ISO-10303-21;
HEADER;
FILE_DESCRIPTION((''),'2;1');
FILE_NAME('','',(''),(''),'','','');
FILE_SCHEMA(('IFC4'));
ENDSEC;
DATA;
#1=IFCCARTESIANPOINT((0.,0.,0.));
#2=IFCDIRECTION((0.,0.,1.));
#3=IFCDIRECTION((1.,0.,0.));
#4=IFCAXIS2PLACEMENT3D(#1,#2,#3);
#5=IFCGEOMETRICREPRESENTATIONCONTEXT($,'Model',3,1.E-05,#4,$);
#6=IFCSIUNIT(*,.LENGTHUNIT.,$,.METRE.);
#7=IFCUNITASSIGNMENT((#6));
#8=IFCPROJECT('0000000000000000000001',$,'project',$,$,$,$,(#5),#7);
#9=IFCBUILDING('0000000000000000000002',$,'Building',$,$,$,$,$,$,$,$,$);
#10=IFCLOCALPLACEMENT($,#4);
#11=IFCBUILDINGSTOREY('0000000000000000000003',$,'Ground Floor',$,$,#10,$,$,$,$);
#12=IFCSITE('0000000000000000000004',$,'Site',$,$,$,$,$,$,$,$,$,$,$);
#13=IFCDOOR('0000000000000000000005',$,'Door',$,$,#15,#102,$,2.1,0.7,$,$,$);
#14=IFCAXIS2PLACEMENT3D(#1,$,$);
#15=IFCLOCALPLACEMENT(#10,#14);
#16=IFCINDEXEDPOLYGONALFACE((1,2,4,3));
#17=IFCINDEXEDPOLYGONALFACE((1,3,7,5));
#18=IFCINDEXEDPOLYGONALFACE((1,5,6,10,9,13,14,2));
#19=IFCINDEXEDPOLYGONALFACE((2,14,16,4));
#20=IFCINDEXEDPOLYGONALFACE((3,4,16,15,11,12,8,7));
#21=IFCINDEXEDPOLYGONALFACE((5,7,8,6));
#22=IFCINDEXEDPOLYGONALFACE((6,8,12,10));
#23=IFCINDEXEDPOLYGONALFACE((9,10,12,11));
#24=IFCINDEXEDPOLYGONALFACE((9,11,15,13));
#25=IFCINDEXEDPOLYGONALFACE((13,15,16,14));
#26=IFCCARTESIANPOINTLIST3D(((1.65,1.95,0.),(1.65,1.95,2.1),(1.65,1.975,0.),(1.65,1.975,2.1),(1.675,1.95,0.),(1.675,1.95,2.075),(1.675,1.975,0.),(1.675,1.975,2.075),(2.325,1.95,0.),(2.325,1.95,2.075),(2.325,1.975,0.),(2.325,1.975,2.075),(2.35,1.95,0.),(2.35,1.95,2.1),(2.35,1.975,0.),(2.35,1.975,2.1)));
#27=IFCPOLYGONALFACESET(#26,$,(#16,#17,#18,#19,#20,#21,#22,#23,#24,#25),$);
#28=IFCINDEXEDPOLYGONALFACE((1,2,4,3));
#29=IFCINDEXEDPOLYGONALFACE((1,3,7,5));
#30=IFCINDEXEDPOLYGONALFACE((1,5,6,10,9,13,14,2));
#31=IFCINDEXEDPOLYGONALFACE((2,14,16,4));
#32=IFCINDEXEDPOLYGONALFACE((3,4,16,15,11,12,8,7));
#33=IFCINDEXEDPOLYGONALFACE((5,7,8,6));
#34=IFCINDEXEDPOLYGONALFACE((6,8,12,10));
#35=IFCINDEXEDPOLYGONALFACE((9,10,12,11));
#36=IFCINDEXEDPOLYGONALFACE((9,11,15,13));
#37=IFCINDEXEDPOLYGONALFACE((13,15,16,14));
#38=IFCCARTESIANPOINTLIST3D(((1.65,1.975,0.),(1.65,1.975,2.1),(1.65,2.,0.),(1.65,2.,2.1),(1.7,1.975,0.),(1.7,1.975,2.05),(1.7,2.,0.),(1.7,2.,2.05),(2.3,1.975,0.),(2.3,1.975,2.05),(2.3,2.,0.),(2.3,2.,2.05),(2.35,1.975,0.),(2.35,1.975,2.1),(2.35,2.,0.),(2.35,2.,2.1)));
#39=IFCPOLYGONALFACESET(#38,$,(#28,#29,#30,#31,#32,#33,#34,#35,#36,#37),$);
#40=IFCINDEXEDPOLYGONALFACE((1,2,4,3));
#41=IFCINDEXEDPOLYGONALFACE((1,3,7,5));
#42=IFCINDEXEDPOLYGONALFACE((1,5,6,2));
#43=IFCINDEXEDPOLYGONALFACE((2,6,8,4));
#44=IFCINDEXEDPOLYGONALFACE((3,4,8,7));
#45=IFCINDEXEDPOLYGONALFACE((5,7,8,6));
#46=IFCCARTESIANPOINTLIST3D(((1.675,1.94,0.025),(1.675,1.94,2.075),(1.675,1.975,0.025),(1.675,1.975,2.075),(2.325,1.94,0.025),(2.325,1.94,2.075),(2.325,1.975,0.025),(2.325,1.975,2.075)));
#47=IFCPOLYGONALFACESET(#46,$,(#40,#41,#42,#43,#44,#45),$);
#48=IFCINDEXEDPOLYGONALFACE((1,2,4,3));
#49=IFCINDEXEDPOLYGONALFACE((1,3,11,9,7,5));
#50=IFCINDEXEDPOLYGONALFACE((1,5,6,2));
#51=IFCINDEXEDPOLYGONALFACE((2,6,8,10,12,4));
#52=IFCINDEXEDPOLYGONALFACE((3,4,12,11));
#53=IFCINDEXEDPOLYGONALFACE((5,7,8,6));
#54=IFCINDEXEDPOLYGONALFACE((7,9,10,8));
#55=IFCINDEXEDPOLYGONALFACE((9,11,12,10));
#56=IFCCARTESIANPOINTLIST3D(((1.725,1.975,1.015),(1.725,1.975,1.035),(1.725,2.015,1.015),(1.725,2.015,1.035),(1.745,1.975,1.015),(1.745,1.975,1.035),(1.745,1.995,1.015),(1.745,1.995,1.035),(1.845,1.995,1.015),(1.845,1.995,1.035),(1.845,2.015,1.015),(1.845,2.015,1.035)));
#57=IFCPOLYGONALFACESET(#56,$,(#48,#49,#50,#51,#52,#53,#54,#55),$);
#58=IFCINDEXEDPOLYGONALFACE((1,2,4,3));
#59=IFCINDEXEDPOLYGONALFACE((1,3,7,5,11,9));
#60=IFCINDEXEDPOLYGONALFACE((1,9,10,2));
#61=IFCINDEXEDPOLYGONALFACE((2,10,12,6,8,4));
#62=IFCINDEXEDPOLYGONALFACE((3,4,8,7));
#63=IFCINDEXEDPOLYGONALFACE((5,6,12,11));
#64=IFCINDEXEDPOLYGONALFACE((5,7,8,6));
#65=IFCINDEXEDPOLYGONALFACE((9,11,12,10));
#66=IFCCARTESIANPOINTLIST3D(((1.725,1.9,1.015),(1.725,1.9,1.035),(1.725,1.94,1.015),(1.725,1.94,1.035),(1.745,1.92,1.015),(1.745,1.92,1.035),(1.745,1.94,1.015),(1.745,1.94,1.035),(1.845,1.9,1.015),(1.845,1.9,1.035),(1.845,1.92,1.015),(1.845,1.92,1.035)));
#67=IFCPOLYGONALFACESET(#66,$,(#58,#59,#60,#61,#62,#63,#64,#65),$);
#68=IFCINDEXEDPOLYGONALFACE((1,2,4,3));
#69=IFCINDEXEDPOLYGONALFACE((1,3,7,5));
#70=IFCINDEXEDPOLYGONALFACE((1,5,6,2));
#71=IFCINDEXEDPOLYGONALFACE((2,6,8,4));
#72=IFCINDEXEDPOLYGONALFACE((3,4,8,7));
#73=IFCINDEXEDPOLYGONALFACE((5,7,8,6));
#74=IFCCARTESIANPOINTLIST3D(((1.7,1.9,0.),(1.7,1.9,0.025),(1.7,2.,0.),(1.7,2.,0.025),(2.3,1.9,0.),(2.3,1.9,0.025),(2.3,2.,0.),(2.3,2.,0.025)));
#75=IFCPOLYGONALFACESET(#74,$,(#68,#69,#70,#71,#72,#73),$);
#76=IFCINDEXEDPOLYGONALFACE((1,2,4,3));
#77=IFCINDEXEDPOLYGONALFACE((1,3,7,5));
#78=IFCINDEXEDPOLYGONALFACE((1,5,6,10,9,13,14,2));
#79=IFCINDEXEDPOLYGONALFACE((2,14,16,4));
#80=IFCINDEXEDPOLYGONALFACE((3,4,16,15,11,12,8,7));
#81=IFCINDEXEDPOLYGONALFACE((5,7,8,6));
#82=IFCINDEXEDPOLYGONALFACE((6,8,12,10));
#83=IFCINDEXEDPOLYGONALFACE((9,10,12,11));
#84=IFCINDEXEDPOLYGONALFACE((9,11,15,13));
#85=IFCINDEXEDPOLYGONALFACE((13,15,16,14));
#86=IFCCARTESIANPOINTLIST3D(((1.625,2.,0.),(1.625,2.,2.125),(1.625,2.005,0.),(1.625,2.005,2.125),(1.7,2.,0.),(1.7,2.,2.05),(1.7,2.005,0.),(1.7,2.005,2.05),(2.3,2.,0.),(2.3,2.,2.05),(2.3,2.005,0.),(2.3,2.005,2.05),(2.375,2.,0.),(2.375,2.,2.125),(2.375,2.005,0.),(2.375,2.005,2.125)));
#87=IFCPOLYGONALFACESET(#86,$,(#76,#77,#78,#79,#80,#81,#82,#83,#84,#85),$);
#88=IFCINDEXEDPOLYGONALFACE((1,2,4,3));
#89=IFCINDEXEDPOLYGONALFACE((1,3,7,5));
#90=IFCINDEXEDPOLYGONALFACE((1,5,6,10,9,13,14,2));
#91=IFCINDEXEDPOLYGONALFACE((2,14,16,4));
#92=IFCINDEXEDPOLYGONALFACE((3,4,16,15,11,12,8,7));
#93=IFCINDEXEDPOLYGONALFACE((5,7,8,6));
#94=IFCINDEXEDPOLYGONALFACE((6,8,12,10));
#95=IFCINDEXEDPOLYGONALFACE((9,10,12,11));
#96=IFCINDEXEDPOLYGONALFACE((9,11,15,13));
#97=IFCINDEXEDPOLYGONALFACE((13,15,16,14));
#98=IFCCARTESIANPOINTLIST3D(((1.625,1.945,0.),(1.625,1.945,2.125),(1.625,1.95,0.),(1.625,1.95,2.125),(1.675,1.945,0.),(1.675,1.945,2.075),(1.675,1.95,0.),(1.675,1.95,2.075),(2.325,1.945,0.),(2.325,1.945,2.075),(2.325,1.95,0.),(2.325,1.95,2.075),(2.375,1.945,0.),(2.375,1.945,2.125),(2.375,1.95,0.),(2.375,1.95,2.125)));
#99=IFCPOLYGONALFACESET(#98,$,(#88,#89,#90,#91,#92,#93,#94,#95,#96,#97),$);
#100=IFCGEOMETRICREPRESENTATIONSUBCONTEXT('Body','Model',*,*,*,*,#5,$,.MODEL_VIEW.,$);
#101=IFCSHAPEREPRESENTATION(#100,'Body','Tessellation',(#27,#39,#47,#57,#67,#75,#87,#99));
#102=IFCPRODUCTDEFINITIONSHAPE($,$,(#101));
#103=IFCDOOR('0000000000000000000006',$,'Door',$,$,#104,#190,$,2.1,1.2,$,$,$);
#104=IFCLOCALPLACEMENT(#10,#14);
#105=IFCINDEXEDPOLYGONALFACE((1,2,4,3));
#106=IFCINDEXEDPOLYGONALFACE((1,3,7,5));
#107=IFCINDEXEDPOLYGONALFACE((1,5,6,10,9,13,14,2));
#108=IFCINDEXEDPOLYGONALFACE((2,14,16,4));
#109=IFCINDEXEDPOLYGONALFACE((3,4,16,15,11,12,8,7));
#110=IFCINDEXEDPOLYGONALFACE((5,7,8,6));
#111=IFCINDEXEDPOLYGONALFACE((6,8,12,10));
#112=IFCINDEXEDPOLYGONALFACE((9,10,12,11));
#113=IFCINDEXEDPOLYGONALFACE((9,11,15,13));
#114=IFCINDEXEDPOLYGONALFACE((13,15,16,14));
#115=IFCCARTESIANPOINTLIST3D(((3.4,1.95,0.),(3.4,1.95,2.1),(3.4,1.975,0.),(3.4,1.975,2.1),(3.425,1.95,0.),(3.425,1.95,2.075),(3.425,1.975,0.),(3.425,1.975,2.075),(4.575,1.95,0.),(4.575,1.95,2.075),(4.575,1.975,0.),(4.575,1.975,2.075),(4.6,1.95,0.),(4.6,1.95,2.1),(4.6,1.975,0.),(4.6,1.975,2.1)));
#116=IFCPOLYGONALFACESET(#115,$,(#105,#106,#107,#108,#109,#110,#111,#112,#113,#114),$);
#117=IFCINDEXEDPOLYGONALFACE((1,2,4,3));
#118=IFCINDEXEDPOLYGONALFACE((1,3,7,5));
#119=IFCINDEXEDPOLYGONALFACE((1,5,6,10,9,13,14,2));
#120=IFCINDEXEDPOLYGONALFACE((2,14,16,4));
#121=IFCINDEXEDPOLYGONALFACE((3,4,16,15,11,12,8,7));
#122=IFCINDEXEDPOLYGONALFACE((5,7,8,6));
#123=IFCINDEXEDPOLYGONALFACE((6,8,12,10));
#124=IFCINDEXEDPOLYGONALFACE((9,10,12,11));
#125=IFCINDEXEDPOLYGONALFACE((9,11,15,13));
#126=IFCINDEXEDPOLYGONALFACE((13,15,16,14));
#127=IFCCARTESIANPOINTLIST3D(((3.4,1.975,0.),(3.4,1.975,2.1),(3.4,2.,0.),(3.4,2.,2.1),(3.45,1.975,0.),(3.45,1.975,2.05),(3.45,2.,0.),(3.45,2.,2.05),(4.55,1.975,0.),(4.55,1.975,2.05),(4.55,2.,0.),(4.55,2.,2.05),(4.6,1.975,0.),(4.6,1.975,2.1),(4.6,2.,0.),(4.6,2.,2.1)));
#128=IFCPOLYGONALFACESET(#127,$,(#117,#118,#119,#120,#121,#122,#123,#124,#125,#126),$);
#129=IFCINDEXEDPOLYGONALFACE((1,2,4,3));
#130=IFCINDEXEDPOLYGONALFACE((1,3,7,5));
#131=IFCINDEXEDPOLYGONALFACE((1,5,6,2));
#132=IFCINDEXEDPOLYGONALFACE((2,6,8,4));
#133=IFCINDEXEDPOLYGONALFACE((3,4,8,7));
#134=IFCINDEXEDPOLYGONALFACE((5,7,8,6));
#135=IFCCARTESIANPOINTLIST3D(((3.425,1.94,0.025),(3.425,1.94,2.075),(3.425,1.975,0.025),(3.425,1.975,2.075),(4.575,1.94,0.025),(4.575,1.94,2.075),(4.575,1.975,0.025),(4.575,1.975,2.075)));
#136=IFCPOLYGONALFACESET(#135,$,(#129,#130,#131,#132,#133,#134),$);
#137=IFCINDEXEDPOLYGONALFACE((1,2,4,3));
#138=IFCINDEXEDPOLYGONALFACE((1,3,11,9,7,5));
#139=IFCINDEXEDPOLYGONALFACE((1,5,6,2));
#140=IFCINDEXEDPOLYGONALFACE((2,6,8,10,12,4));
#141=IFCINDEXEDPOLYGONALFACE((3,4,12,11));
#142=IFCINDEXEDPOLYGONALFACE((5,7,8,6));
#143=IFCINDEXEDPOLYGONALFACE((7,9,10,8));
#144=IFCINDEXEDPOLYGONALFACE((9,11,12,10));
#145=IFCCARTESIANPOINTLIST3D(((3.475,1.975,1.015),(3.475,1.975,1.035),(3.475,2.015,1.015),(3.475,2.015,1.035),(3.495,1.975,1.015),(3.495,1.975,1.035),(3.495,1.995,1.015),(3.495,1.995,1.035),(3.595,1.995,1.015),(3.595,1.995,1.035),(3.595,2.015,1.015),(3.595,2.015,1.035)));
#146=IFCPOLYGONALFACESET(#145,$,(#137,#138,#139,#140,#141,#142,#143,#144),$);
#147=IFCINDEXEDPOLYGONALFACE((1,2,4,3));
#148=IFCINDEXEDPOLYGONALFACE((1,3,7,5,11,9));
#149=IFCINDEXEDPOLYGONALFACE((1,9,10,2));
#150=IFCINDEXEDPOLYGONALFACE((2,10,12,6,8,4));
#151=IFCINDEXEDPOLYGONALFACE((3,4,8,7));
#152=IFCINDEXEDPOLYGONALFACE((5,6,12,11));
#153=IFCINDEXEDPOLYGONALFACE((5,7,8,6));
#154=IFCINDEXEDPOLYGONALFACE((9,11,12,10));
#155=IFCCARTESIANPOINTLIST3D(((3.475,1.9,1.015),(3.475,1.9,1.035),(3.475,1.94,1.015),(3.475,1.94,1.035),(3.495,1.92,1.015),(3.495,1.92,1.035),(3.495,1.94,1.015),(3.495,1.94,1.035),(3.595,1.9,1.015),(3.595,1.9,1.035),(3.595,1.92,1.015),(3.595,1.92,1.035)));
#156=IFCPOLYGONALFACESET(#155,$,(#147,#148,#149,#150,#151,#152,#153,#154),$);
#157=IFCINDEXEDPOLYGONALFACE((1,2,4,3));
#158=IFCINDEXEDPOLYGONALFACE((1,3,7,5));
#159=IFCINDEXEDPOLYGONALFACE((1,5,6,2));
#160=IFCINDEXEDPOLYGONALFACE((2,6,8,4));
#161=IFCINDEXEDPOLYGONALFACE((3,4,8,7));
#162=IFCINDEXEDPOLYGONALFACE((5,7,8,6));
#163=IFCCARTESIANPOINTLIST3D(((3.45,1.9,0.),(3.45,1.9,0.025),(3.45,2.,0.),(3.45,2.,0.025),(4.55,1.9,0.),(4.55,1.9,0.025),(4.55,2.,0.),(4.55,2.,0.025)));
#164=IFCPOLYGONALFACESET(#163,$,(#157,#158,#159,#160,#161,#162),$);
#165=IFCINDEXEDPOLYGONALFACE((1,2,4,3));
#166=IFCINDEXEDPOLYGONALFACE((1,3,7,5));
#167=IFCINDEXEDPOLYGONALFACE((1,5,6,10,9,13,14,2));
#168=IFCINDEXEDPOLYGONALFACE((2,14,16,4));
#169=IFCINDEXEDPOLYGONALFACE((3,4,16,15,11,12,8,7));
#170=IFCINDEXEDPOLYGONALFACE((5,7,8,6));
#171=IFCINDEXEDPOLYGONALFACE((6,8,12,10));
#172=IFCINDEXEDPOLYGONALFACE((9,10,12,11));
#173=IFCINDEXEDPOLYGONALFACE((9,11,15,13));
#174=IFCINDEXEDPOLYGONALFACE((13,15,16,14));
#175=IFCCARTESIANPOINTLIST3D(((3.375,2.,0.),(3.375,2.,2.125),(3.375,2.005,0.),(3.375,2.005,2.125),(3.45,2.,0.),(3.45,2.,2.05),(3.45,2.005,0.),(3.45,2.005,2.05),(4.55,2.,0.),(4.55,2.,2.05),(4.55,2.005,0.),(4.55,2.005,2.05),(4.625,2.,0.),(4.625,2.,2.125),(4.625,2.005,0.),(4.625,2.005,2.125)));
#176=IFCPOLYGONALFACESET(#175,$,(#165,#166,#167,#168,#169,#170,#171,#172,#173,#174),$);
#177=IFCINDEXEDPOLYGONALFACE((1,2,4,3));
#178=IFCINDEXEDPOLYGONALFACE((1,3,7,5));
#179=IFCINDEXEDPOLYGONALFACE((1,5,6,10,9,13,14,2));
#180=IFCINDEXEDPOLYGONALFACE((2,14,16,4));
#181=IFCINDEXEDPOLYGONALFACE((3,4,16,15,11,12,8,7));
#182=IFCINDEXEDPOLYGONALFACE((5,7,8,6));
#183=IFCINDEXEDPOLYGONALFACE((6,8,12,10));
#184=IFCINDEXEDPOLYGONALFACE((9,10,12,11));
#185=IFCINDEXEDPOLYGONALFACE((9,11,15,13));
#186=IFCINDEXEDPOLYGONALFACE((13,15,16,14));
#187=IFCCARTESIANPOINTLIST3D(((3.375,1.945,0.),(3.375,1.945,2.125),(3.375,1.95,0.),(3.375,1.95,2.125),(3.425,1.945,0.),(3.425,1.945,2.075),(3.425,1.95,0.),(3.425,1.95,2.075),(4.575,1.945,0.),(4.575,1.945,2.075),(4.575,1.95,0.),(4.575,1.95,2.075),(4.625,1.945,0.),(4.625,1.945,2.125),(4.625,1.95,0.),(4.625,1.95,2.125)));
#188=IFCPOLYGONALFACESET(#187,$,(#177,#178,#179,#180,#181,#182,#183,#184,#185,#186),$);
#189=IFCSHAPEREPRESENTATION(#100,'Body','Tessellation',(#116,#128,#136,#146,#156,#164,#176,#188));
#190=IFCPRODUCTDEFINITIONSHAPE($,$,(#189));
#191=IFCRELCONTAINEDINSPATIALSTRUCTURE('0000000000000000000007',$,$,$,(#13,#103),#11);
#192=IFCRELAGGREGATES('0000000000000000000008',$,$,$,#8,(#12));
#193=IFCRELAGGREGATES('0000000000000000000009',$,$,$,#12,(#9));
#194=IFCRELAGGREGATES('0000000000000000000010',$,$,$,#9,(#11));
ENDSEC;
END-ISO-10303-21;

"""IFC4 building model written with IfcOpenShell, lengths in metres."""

from ifc_helpers import new_model, si_unit, frame, origin_with_axes, place, context, subcontext, project, spatial, line, indexed_curve, outline, extrude, element, save


model = new_model("IFC4")

# Units and contexts
model_context = context("Model", 3, precision=1e-05, world=origin_with_axes())
body_context = subcontext(model_context, "Body", "Model", "MODEL_VIEW")
ifc_project = project(units=[si_unit("LENGTHUNIT", "METRE")], contexts=[model_context])

# Site, building, storey
site = spatial("IfcSite", under=ifc_project, Name="Site")
building = spatial("IfcBuilding", under=site, Name="Building")
storey_placement = place(None, origin_with_axes())
storey = spatial("IfcBuildingStorey", under=building, at=storey_placement, Name="Ground Floor")

# Doors
door_1_placement = place(storey_placement, frame((2.35, 2.0, 0.0), z_axis=(0.0, 0.0, 1.0), x_axis=(-1.0, 0.0, 0.0)))
element("IfcDoor", 1, at=door_1_placement, inside=storey, Name="Door", OverallHeight=2.1, OverallWidth=0.7, context=body_context, shape_type="SweptSolid", body=[
    extrude(outline(indexed_curve([(0.0, 0.0), (0.0, 2.1), (0.7, 2.1), (0.7, 0.0), (0.675, 0.0), (0.675, 2.075), (0.025, 2.075), (0.025, 0.0)], segments=[line(1, 2, 3, 4, 5, 6, 7, 8, 1)])), frame((0.0, 0.025, 0.0), z_axis=(0.0, -1.0, 0.0), x_axis=(1.0, 0.0, 0.0)), (0.0, 0.0, -1.0), 0.025),
    extrude(outline(indexed_curve([(0.0, 0.0), (0.0, 2.1), (0.7, 2.1), (0.7, 0.0), (0.65, 0.0), (0.65, 2.05), (0.05, 2.05), (0.05, 0.0)], segments=[line(1, 2, 3, 4, 5, 6, 7, 8, 1)])), frame((0.0, 0.0, 0.0), z_axis=(0.0, -1.0, 0.0), x_axis=(1.0, 0.0, 0.0)), (0.0, 0.0, -1.0), 0.025),
    extrude(outline(indexed_curve([(0.0, 0.0), (0.65, 0.0), (0.65, 0.035), (0.0, 0.035)], segments=[line(1, 2, 3, 4, 1)])), frame((0.025, 0.025, 0.025), z_axis=(0.0, 0.0, 1.0), x_axis=(1.0, 0.0, 0.0)), (0.0, 0.0, 1.0), 2.05),
    extrude(outline(indexed_curve([(0.0, 0.0), (0.0, -0.04), (-0.12, -0.04), (-0.12, -0.02), (-0.02, -0.02), (-0.02, 0.0)], segments=[line(1, 2, 3, 4, 5, 6, 1)])), frame((0.625, 0.025, 1.015), z_axis=(0.0, 0.0, 1.0), x_axis=(1.0, 0.0, 0.0)), (0.0, 0.0, 1.0), 0.02),
    extrude(outline(indexed_curve([(0.0, 0.0), (0.0, 0.04), (-0.12, 0.04), (-0.12, 0.02), (-0.02, 0.02), (-0.02, 0.0)], segments=[line(1, 2, 3, 4, 5, 6, 1)])), frame((0.625, 0.06, 1.015), z_axis=(0.0, 0.0, 1.0), x_axis=(1.0, 0.0, 0.0)), (0.0, 0.0, 1.0), 0.02),
    extrude(outline(indexed_curve([(0.0, 0.0), (0.6, 0.0), (0.6, 0.1), (0.0, 0.1)], segments=[line(1, 2, 3, 4, 1)])), frame((0.05, 0.0, 0.0), z_axis=(0.0, 0.0, 1.0), x_axis=(1.0, 0.0, 0.0)), (0.0, 0.0, 1.0), 0.025),
    extrude(outline(indexed_curve([(0.0, 0.0), (0.0, 2.125), (0.75, 2.125), (0.75, 0.0), (0.675, 0.0), (0.675, 2.05), (0.075, 2.05), (0.075, 0.0)], segments=[line(1, 2, 3, 4, 5, 6, 7, 8, 1)])), frame((-0.025, -0.005, 0.0), z_axis=(0.0, -1.0, 0.0), x_axis=(1.0, 0.0, 0.0)), (0.0, 0.0, -1.0), 0.005),
    extrude(outline(indexed_curve([(0.0, 0.0), (0.0, 2.125), (0.75, 2.125), (0.75, 0.0), (0.7, 0.0), (0.7, 2.075), (0.05, 2.075), (0.05, 0.0)], segments=[line(1, 2, 3, 4, 5, 6, 7, 8, 1)])), frame((-0.025, 0.05, 0.0), z_axis=(0.0, -1.0, 0.0), x_axis=(1.0, 0.0, 0.0)), (0.0, 0.0, -1.0), 0.005),
])
door_2_placement = place(storey_placement, frame((4.6, 2.0, 0.0), z_axis=(0.0, 0.0, 1.0), x_axis=(-1.0, 0.0, 0.0)))
element("IfcDoor", 2, at=door_2_placement, inside=storey, Name="Door", OverallHeight=2.1, OverallWidth=1.2, context=body_context, shape_type="SweptSolid", body=[
    extrude(outline(indexed_curve([(0.0, 0.0), (0.0, 2.1), (1.2, 2.1), (1.2, 0.0), (1.175, 0.0), (1.175, 2.075), (0.025, 2.075), (0.025, 0.0)], segments=[line(1, 2, 3, 4, 5, 6, 7, 8, 1)])), frame((0.0, 0.025, 0.0), z_axis=(0.0, -1.0, 0.0), x_axis=(1.0, 0.0, 0.0)), (0.0, 0.0, -1.0), 0.025),
    extrude(outline(indexed_curve([(0.0, 0.0), (0.0, 2.1), (1.2, 2.1), (1.2, 0.0), (1.15, 0.0), (1.15, 2.05), (0.05, 2.05), (0.05, 0.0)], segments=[line(1, 2, 3, 4, 5, 6, 7, 8, 1)])), frame((0.0, 0.0, 0.0), z_axis=(0.0, -1.0, 0.0), x_axis=(1.0, 0.0, 0.0)), (0.0, 0.0, -1.0), 0.025),
    extrude(outline(indexed_curve([(0.0, 0.0), (1.15, 0.0), (1.15, 0.035), (0.0, 0.035)], segments=[line(1, 2, 3, 4, 1)])), frame((0.025, 0.025, 0.025), z_axis=(0.0, 0.0, 1.0), x_axis=(1.0, 0.0, 0.0)), (0.0, 0.0, 1.0), 2.05),
    extrude(outline(indexed_curve([(0.0, 0.0), (0.0, -0.04), (-0.12, -0.04), (-0.12, -0.02), (-0.02, -0.02), (-0.02, 0.0)], segments=[line(1, 2, 3, 4, 5, 6, 1)])), frame((1.125, 0.025, 1.015), z_axis=(0.0, 0.0, 1.0), x_axis=(1.0, 0.0, 0.0)), (0.0, 0.0, 1.0), 0.02),
    extrude(outline(indexed_curve([(0.0, 0.0), (0.0, 0.04), (-0.12, 0.04), (-0.12, 0.02), (-0.02, 0.02), (-0.02, 0.0)], segments=[line(1, 2, 3, 4, 5, 6, 1)])), frame((1.125, 0.06, 1.015), z_axis=(0.0, 0.0, 1.0), x_axis=(1.0, 0.0, 0.0)), (0.0, 0.0, 1.0), 0.02),
    extrude(outline(indexed_curve([(0.0, 0.0), (1.1, 0.0), (1.1, 0.1), (0.0, 0.1)], segments=[line(1, 2, 3, 4, 1)])), frame((0.05, 0.0, 0.0), z_axis=(0.0, 0.0, 1.0), x_axis=(1.0, 0.0, 0.0)), (0.0, 0.0, 1.0), 0.025),
    extrude(outline(indexed_curve([(0.0, 0.0), (0.0, 2.125), (1.25, 2.125), (1.25, 0.0), (1.175, 0.0), (1.175, 2.05), (0.075, 2.05), (0.075, 0.0)], segments=[line(1, 2, 3, 4, 5, 6, 7, 8, 1)])), frame((-0.025, -0.005, 0.0), z_axis=(0.0, -1.0, 0.0), x_axis=(1.0, 0.0, 0.0)), (0.0, 0.0, -1.0), 0.005),
    extrude(outline(indexed_curve([(0.0, 0.0), (0.0, 2.125), (1.25, 2.125), (1.25, 0.0), (1.2, 0.0), (1.2, 2.075), (0.05, 2.075), (0.05, 0.0)], segments=[line(1, 2, 3, 4, 5, 6, 7, 8, 1)])), frame((-0.025, 0.05, 0.0), z_axis=(0.0, -1.0, 0.0), x_axis=(1.0, 0.0, 0.0)), (0.0, 0.0, -1.0), 0.005),
])

save(model, "model.ifc")
